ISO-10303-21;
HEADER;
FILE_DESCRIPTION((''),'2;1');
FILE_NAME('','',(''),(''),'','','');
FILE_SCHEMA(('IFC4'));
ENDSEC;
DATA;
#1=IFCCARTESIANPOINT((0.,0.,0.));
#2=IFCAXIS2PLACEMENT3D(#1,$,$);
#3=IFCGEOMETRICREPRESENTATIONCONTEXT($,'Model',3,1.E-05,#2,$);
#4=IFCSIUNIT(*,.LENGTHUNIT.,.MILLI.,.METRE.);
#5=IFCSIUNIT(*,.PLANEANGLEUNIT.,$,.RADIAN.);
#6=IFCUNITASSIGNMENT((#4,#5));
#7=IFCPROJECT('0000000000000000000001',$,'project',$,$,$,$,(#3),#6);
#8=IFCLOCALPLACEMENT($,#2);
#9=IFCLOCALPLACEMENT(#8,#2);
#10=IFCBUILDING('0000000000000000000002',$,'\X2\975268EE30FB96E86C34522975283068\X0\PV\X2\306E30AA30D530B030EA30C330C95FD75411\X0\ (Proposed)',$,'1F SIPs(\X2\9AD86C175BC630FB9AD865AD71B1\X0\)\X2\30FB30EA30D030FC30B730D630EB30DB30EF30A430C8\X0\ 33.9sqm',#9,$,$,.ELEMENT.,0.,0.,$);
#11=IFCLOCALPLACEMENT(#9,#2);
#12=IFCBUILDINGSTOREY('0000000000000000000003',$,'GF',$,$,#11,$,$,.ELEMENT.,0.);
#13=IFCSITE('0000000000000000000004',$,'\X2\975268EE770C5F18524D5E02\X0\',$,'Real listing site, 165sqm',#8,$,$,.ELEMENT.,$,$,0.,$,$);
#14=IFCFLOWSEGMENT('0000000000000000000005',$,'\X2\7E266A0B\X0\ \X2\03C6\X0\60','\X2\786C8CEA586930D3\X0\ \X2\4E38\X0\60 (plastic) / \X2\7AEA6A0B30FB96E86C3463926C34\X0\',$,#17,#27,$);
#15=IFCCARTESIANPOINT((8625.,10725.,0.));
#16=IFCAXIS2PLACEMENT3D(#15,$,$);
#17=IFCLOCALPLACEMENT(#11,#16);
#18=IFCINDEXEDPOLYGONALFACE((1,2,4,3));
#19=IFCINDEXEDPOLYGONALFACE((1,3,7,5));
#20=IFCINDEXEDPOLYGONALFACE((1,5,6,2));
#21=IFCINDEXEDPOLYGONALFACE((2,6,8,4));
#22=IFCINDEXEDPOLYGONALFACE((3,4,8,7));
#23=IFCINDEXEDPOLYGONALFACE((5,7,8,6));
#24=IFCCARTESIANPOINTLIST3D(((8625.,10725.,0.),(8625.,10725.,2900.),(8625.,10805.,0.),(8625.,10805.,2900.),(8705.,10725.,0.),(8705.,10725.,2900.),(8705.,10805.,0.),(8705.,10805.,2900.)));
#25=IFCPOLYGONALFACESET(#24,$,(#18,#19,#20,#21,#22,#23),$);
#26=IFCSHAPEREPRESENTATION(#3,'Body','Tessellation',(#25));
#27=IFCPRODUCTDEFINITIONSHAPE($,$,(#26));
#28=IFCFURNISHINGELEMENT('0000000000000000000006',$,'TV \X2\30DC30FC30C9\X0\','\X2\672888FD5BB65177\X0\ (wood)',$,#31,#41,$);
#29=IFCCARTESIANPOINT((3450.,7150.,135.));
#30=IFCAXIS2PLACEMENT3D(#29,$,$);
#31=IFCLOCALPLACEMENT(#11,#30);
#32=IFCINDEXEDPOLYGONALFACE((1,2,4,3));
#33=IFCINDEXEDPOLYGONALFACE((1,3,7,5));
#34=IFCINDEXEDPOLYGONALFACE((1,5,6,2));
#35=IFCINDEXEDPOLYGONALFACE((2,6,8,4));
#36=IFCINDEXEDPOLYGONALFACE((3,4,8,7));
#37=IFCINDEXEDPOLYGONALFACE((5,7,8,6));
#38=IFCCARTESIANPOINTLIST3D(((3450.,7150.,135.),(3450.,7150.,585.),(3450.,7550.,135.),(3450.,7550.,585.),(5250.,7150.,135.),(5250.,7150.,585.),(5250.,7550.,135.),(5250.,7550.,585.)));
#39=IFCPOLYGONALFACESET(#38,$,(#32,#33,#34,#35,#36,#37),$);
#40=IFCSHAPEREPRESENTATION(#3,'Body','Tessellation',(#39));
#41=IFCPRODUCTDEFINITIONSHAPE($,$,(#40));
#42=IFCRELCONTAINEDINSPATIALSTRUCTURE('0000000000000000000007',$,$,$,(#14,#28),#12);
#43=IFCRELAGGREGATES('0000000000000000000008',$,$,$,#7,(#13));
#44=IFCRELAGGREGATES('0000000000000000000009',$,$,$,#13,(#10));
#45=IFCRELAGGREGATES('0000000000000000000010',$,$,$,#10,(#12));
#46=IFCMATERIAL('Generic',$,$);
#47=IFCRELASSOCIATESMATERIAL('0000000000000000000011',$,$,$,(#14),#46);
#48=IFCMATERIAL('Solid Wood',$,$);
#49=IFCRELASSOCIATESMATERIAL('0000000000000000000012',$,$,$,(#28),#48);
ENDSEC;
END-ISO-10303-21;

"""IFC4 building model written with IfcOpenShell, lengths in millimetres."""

from ifc_helpers import new_model, si_unit, frame, frame_2d, origin, place, context, project, spatial, rectangle, extrude, material, element, save


model = new_model("IFC4")

# Units and contexts
model_context = context("Model", 3, precision=1e-05, world=origin())
ifc_project = project(units=[si_unit("LENGTHUNIT", "METRE", prefix="MILLI"), si_unit("PLANEANGLEUNIT", "RADIAN")], contexts=[model_context])

# Site, building, storey
site_placement = place(None, origin())
site = spatial("IfcSite", under=ifc_project, at=site_placement, Name="青森県弘前市", ObjectType="Real listing site, 165sqm", CompositionType="ELEMENT", RefElevation=0.0)
building_placement = place(site_placement, origin())
building = spatial("IfcBuilding", under=site, at=building_placement, Name="青森・雨水利用とPVのオフグリッド志向 (Proposed)", ObjectType="1F SIPs(高気密・高断熱)・リバーシブルホワイト 33.9sqm", CompositionType="ELEMENT", ElevationOfRefHeight=0.0, ElevationOfTerrain=0.0)
storey_placement = place(building_placement, origin())
storey = spatial("IfcBuildingStorey", under=building, at=storey_placement, Name="GF", CompositionType="ELEMENT", Elevation=0.0)

# Shared definitions
ifc_material_1 = material(Name="Solid Wood")

# Shared definitions
ifc_material_2 = material(Name="Generic")

# Flow segment
flow_segment_placement = place(storey_placement, frame((8625.0, 10725.0, 0.0)))
element("IfcFlowSegment", 1, at=flow_segment_placement, inside=storey, material=ifc_material_2, Name="縦樋 φ60", Description="硬質塩ビ 丸60 (plastic) / 竪樋・雨水排水", context=model_context, shape_type="SweptSolid", body=[
    extrude(rectangle(XDim=80.0, YDim=80.0, at=frame_2d((40.0, 40.0))), frame((8625.0, 10725.0, 0.0)), (0.0, 0.0, 1.0), 2900.0),
])

# Furnishing element
furnishing_placement = place(storey_placement, frame((3450.0, 7150.0, 135.0)))
element("IfcFurnishingElement", 2, at=furnishing_placement, inside=storey, material=ifc_material_1, Name="TV ボード", Description="木製家具 (wood)", context=model_context, shape_type="SweptSolid", body=[
    extrude(rectangle(XDim=1800.0, YDim=400.0, at=frame_2d((900.0, 200.0))), frame((3450.0, 7150.0, 135.0)), (0.0, 0.0, 1.0), 450.0),
])

save(model, "model.ifc")
